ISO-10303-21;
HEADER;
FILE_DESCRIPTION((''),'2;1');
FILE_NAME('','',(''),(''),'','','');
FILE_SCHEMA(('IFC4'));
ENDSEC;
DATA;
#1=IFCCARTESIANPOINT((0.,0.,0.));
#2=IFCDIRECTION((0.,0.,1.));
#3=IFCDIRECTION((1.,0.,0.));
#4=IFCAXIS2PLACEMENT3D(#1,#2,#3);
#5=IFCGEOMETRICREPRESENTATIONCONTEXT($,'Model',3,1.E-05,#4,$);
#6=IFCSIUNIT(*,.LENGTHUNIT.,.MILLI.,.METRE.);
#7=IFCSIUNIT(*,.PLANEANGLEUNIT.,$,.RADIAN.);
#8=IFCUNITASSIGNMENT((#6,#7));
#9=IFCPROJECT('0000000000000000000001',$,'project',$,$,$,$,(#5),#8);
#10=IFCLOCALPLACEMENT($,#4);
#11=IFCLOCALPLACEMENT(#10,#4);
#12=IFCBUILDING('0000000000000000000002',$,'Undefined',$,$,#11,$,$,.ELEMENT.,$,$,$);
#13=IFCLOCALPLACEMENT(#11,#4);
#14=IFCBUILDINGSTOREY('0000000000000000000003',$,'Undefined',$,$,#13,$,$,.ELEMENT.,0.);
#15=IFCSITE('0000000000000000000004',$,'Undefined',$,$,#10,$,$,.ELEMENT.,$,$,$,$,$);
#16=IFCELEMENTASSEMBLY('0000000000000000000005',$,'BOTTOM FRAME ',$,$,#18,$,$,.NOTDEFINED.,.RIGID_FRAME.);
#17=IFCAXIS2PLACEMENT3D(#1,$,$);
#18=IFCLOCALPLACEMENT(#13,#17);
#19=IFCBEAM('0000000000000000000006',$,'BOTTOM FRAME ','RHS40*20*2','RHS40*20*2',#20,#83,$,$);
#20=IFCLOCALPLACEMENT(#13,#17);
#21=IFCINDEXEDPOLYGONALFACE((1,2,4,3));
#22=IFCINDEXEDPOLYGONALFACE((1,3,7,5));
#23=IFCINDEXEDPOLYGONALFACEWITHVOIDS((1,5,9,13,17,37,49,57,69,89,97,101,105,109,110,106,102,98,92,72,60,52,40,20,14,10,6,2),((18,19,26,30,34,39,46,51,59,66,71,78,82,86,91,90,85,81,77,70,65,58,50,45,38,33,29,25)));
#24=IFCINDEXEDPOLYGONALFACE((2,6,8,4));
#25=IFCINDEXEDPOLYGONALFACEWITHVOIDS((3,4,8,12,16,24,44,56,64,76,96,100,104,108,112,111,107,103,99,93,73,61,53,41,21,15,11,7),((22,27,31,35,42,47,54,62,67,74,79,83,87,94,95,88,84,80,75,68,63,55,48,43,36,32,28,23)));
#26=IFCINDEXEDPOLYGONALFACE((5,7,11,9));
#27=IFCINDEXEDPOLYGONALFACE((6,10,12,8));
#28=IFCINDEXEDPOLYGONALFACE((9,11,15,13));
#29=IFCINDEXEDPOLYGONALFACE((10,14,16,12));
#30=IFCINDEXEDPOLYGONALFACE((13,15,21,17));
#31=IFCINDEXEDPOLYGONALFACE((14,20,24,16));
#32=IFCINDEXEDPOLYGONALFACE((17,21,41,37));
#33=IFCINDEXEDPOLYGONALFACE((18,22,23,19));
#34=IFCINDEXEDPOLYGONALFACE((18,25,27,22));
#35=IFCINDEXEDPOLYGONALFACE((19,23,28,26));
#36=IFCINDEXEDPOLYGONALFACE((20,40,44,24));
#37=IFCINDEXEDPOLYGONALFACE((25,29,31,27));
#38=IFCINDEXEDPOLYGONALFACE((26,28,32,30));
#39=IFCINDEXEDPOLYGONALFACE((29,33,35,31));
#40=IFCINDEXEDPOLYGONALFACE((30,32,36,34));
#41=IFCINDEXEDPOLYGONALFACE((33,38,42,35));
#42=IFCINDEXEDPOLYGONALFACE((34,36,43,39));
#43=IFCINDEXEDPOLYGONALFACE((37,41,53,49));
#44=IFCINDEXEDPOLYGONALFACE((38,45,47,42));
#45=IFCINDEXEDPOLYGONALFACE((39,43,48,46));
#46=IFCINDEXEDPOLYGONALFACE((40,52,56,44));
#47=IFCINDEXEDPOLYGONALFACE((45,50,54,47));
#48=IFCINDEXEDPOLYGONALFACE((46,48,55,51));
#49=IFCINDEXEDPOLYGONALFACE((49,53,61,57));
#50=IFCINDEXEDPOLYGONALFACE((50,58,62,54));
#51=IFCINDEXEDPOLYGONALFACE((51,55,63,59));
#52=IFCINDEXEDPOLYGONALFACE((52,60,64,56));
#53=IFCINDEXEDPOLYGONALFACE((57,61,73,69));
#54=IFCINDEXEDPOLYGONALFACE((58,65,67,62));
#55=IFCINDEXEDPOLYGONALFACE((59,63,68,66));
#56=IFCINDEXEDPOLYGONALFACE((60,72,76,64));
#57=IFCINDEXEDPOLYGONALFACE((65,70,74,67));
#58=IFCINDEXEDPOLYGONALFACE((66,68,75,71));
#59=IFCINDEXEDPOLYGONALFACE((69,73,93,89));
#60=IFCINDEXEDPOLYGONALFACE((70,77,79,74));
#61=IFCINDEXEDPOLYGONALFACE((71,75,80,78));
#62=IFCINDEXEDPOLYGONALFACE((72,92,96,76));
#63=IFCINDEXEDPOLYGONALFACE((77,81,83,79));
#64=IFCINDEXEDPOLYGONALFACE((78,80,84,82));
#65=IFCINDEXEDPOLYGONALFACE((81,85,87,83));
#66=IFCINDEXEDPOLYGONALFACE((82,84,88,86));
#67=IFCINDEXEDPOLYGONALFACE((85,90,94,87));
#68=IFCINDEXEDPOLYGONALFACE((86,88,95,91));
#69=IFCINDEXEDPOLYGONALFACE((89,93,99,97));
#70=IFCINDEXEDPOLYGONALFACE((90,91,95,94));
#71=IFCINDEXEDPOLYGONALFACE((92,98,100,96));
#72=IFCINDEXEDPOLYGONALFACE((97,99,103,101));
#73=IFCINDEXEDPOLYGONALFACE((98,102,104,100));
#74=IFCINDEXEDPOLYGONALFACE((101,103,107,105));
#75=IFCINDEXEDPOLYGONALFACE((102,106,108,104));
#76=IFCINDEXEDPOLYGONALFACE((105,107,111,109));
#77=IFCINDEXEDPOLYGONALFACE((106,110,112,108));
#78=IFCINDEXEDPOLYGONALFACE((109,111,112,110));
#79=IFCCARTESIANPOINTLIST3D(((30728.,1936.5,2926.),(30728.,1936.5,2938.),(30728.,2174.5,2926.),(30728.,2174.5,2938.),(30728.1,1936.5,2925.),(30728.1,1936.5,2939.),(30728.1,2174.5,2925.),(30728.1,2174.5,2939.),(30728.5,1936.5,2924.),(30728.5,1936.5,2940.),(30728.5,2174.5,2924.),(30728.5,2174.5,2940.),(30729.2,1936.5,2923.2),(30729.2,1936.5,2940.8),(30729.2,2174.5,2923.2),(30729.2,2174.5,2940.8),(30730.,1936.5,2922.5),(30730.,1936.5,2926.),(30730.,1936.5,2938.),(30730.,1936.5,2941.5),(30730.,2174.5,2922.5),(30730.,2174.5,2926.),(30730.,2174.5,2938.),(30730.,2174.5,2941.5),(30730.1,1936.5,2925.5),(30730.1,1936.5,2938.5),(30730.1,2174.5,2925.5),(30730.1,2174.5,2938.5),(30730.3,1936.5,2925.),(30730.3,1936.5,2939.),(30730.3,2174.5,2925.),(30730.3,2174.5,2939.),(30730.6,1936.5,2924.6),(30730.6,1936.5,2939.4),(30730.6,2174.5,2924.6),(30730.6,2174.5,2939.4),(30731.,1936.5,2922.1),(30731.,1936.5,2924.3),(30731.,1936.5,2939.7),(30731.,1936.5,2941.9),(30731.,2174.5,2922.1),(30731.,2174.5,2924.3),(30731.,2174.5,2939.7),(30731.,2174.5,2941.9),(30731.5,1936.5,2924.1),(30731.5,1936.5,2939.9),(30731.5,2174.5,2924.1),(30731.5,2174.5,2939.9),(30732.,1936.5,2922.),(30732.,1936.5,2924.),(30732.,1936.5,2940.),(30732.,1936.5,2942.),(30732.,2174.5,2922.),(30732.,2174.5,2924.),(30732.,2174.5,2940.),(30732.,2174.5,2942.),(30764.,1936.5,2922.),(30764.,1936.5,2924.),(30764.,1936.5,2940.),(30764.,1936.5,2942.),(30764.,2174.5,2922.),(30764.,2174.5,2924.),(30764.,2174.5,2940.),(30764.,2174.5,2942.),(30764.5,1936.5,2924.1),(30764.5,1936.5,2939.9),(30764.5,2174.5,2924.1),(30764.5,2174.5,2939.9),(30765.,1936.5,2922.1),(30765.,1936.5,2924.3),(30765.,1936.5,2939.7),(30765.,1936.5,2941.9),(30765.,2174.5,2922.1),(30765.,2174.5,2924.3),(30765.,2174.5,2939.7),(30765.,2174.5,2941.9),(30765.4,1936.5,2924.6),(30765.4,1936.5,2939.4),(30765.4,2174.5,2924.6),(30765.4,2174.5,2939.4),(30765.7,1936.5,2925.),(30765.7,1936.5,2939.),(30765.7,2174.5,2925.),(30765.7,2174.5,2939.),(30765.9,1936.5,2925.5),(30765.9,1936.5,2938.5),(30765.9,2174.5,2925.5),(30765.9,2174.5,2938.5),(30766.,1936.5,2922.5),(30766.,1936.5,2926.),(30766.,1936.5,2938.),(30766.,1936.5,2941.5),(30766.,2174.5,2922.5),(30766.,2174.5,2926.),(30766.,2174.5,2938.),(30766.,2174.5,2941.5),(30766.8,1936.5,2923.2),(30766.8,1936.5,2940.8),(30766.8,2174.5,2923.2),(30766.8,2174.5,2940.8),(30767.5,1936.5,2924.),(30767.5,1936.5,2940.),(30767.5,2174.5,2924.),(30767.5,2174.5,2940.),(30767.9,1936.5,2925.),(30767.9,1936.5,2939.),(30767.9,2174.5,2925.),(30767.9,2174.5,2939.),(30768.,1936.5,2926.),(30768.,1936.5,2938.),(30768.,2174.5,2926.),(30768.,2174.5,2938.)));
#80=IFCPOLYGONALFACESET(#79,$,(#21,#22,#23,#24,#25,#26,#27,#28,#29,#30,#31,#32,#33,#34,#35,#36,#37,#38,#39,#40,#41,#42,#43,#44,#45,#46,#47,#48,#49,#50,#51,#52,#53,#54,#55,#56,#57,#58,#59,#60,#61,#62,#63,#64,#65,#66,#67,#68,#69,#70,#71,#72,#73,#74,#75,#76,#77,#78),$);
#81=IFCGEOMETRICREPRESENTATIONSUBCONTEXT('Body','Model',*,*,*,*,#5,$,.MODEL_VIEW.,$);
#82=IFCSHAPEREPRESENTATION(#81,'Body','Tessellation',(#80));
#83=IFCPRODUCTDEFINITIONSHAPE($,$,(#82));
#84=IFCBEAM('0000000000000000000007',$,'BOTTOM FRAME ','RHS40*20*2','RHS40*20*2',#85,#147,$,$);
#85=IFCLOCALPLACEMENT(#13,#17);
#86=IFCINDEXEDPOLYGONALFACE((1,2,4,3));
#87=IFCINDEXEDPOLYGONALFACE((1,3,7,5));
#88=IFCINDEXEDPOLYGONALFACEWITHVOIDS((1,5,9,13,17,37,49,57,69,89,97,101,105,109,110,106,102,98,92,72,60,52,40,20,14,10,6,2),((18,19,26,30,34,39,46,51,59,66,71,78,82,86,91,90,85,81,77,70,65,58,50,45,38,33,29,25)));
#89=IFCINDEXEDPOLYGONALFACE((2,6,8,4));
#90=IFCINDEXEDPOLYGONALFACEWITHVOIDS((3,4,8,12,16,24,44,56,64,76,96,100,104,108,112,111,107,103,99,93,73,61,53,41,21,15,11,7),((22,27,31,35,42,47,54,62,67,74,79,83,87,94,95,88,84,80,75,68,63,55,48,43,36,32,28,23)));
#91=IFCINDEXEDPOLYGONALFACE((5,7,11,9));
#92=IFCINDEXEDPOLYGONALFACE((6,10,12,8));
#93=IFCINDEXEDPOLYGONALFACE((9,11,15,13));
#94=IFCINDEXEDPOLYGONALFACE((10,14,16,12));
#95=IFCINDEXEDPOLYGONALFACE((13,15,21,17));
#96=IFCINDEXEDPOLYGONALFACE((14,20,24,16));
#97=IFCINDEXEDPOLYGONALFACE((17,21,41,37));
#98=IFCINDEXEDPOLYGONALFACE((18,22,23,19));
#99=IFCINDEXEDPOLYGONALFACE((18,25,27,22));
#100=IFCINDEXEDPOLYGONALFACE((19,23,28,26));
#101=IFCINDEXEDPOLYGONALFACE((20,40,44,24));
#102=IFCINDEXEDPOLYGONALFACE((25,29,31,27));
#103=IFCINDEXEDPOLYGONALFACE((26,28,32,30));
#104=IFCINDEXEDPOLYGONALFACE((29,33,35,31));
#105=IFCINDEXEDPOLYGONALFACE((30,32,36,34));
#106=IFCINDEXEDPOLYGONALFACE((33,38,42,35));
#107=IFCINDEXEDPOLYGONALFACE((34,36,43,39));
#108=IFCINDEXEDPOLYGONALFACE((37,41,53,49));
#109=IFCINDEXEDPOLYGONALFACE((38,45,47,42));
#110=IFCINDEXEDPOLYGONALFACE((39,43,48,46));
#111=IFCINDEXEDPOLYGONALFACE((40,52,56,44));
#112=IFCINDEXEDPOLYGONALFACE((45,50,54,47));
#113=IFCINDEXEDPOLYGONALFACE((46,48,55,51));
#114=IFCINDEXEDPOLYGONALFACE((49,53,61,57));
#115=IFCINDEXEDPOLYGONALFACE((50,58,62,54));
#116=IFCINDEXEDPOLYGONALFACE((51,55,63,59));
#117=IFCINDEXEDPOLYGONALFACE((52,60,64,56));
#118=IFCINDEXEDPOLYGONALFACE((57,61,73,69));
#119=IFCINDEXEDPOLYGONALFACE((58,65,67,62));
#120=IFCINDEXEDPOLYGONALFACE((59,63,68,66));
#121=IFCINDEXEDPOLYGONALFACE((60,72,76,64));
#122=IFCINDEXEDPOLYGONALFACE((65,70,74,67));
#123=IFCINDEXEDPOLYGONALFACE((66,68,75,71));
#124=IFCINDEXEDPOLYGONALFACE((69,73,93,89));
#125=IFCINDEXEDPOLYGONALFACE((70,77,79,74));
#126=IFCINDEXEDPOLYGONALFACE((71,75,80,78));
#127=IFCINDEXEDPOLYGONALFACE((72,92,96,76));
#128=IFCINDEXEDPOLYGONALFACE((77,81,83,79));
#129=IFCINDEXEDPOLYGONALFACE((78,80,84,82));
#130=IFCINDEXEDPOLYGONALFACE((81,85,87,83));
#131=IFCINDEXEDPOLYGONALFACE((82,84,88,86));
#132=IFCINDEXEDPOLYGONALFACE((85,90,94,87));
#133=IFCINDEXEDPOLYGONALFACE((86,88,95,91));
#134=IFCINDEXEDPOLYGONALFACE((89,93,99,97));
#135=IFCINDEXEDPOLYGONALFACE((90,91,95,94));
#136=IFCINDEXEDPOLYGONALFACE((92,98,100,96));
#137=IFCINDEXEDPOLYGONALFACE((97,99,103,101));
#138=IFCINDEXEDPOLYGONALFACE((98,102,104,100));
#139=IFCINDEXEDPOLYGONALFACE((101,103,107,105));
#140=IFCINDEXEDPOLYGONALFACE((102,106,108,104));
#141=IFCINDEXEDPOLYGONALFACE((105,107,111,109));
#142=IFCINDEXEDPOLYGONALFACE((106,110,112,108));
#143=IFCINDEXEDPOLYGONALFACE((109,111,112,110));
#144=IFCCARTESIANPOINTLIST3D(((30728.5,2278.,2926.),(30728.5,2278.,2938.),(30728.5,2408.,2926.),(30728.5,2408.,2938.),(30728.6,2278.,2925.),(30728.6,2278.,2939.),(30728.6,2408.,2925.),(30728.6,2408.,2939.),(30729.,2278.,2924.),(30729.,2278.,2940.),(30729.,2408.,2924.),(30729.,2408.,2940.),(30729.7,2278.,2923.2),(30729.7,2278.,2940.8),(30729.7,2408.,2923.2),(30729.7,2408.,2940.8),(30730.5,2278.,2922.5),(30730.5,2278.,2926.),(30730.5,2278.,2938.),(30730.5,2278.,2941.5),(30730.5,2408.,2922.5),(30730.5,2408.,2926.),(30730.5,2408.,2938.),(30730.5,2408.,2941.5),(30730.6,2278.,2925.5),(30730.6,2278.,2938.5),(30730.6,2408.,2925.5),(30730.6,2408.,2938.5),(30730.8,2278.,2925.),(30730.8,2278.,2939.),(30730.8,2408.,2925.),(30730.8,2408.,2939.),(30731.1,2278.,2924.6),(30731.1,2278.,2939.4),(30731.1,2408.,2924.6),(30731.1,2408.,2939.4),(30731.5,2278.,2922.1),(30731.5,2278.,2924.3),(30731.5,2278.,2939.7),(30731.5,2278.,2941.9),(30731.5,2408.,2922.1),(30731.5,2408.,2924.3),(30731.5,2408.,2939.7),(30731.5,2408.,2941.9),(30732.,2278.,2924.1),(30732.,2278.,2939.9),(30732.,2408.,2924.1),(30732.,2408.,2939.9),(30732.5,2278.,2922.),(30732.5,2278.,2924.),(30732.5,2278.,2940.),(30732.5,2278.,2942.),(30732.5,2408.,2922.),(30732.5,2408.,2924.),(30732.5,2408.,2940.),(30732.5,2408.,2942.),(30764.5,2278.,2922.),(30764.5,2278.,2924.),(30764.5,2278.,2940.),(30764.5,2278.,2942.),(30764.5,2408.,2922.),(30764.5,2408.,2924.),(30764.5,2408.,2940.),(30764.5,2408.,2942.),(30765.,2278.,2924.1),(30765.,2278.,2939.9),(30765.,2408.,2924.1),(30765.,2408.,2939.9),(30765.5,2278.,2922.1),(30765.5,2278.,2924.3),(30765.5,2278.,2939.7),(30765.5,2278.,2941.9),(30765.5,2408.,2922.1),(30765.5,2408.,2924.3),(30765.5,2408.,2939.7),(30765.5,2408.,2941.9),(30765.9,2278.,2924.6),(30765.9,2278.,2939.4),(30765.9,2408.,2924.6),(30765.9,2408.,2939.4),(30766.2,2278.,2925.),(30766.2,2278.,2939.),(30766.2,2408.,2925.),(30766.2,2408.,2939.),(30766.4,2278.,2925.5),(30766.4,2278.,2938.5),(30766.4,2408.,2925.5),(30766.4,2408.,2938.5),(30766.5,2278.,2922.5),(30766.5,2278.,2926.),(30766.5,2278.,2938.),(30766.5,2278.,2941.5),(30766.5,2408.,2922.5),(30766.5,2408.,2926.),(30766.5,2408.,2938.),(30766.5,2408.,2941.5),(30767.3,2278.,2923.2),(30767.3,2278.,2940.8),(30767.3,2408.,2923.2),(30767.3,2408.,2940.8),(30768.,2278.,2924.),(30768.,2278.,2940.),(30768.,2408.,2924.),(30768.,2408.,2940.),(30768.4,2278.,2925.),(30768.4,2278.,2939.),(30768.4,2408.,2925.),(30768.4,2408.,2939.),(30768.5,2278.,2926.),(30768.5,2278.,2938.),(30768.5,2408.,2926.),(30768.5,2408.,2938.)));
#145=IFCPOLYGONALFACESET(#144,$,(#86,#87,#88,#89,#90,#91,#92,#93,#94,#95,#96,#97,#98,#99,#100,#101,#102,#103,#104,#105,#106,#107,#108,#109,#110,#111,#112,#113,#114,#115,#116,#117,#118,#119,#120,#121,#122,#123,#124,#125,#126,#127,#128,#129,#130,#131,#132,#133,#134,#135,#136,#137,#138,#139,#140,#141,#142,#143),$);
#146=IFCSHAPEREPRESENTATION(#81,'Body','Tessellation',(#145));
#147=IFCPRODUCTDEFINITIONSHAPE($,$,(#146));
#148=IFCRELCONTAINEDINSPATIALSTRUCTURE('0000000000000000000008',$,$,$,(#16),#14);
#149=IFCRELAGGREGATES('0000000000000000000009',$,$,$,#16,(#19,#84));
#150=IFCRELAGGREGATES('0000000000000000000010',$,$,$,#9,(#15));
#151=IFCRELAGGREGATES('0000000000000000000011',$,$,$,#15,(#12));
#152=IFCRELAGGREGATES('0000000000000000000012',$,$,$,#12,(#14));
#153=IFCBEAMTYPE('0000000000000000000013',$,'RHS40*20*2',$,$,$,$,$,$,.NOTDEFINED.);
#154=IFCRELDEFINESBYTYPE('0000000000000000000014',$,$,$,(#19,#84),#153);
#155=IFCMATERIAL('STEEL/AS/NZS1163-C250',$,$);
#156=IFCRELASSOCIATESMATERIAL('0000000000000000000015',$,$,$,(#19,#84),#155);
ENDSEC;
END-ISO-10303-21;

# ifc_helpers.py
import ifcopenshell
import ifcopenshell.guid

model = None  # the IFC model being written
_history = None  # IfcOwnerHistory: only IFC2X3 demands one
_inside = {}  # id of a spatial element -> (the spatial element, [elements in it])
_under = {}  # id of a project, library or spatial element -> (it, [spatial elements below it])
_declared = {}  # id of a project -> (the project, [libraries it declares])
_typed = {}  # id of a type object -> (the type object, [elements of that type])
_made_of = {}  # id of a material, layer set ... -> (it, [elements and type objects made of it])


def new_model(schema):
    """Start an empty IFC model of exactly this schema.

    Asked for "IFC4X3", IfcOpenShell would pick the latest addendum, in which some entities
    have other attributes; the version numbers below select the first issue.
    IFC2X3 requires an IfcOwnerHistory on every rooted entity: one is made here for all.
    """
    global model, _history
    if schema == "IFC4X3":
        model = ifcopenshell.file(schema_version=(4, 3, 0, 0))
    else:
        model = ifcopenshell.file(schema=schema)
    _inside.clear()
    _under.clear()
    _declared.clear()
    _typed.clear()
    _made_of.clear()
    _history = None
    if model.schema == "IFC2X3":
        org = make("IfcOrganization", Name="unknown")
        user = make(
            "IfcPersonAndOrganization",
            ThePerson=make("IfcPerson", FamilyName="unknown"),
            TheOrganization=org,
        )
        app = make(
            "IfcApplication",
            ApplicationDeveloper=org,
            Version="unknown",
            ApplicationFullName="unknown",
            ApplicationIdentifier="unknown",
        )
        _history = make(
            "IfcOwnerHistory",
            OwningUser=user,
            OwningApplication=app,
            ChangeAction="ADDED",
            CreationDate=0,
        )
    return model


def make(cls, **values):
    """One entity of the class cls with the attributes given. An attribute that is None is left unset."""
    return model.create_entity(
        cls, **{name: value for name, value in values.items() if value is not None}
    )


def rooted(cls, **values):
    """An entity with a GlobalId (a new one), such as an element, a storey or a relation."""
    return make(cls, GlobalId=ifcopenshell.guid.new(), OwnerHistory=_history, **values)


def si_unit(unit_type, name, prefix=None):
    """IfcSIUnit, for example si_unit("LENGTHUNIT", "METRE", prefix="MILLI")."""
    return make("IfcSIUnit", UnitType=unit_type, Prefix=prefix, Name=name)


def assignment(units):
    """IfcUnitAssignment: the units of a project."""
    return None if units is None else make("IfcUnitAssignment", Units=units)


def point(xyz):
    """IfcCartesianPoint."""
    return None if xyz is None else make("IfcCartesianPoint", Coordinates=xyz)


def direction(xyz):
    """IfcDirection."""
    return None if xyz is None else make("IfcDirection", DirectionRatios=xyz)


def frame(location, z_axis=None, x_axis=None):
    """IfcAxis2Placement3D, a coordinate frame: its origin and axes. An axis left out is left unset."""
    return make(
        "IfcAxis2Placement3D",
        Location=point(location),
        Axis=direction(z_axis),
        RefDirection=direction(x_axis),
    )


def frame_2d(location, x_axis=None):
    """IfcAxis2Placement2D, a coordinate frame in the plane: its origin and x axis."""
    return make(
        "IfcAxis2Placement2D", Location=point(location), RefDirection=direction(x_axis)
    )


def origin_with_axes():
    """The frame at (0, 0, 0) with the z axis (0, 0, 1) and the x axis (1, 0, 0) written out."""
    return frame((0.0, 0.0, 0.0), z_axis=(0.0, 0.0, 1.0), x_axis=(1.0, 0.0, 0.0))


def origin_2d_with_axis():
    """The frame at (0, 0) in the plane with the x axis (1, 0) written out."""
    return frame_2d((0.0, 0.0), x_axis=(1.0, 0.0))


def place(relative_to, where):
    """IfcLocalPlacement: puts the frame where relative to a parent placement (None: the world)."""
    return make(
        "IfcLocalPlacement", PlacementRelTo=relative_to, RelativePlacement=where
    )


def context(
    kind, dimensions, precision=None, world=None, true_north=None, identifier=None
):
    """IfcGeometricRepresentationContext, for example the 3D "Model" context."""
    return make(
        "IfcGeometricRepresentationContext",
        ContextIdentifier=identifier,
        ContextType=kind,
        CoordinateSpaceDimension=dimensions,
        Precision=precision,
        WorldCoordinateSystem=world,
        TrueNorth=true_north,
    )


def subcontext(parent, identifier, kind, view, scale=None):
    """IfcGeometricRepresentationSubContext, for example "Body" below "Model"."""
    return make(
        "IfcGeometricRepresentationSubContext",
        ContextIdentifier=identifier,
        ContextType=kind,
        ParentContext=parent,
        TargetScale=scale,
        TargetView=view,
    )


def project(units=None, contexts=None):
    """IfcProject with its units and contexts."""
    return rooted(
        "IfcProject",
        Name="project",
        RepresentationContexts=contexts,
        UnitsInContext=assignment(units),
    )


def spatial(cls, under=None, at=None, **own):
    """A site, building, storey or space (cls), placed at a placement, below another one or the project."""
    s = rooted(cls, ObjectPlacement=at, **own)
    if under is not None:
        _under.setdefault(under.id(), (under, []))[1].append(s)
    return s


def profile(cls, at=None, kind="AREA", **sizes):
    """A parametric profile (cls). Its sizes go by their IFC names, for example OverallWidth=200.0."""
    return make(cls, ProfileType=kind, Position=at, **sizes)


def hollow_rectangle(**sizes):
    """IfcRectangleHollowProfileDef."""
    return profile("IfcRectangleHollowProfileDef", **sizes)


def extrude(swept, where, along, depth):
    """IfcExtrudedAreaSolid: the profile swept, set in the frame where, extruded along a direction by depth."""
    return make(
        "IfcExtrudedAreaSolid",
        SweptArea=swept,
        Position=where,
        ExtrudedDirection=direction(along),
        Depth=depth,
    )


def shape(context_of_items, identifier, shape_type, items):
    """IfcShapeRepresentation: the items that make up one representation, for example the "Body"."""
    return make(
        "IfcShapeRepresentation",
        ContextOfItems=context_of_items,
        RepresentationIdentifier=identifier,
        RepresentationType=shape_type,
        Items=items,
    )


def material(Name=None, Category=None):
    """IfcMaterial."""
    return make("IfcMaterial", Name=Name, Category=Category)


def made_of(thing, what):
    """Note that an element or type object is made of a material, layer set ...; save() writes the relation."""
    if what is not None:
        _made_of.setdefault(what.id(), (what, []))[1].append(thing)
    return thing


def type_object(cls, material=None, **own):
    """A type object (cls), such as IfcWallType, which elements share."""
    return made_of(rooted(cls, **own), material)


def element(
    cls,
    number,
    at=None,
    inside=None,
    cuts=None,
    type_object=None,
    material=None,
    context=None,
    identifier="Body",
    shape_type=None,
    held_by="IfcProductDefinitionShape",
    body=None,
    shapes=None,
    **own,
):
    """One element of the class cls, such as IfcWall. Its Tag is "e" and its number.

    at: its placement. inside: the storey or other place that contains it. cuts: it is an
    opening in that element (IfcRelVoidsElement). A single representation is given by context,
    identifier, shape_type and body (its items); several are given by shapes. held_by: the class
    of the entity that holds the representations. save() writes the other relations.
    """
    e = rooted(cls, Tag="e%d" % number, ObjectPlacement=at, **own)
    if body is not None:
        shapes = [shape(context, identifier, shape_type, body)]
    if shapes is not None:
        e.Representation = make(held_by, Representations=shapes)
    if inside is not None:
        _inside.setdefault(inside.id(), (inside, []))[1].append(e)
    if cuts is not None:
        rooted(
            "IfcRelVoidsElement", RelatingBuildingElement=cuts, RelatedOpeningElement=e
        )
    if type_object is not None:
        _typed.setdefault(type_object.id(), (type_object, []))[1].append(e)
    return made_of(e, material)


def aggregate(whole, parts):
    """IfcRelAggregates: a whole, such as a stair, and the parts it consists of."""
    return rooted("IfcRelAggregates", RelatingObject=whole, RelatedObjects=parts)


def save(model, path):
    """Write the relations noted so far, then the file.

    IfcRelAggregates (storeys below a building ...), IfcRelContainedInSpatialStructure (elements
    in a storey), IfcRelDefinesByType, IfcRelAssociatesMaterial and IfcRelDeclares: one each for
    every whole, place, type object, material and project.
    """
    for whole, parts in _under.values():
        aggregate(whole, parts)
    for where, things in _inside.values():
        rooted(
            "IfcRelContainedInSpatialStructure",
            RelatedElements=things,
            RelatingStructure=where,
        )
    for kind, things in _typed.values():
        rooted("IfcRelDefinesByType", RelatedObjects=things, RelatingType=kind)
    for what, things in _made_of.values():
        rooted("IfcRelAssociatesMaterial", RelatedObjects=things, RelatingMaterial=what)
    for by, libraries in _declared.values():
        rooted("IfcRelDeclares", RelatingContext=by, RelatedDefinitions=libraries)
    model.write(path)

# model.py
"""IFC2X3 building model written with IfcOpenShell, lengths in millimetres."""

from ifc_helpers import new_model, si_unit, frame, origin_with_axes, origin_2d_with_axis, place, context, subcontext, project, spatial, hollow_rectangle, extrude, material, type_object, element, aggregate, save


model = new_model("IFC2X3")

# Units and contexts
model_context = context("Model", 3, precision=1e-05, world=origin_with_axes())
body_context = subcontext(model_context, "Body", "Model", "MODEL_VIEW")
ifc_project = project(units=[si_unit("LENGTHUNIT", "METRE", prefix="MILLI"), si_unit("PLANEANGLEUNIT", "RADIAN")], contexts=[model_context])

# Site, building, storey
site_placement = place(None, origin_with_axes())
site = spatial("IfcSite", under=ifc_project, at=site_placement, Name="Undefined", CompositionType="ELEMENT")
building_placement = place(site_placement, origin_with_axes())
building = spatial("IfcBuilding", under=site, at=building_placement, Name="Undefined", CompositionType="ELEMENT")
storey_placement = place(building_placement, origin_with_axes())
storey = spatial("IfcBuildingStorey", under=building, at=storey_placement, Name="Undefined", CompositionType="ELEMENT", Elevation=0.0)

# Element assembly, beams
assembly_1_placement = place(storey_placement, origin_with_axes())
assembly_1 = element("IfcElementAssembly", 1, at=assembly_1_placement, inside=storey, Name="BOTTOM FRAME ", AssemblyPlace="NOTDEFINED", PredefinedType="RIGID_FRAME")
ifc_material_1 = material(Name="STEEL/AS/NZS1163-C250")
beam_type_1 = type_object("IfcBeamType", Name="RHS40*20*2", PredefinedType="NOTDEFINED")
beam_1_placement = place(assembly_1_placement, frame((30748.0, 2174.5, 2932.0), z_axis=(1.0, 0.0, 0.0), x_axis=(0.0, -1.0, 0.0)))
beam_1 = element("IfcBeam", 2, at=beam_1_placement, type_object=beam_type_1, material=ifc_material_1, Name="BOTTOM FRAME ", Description="RHS40*20*2", ObjectType="RHS40*20*2", context=body_context, shape_type="SweptSolid", body=[
    extrude(hollow_rectangle(XDim=20.0, YDim=40.0, WallThickness=2.0, InnerFilletRadius=2.0, OuterFilletRadius=4.0, at=origin_2d_with_axis()), frame((238.0, 0.0, 0.0), z_axis=(-1.0, 0.0, 0.0), x_axis=(0.0, -1.0, 0.0)), (0.0, 0.0, 1.0), 238.0),
])
beam_2_placement = place(assembly_1_placement, frame((30748.5, 2408.0, 2932.0), z_axis=(1.0, 0.0, 0.0), x_axis=(0.0, -1.0, 0.0)))
beam_2 = element("IfcBeam", 3, at=beam_2_placement, type_object=beam_type_1, material=ifc_material_1, Name="BOTTOM FRAME ", Description="RHS40*20*2", ObjectType="RHS40*20*2", context=body_context, shape_type="SweptSolid", body=[
    extrude(hollow_rectangle(XDim=20.0, YDim=40.0, WallThickness=2.0, InnerFilletRadius=2.0, OuterFilletRadius=4.0, at=origin_2d_with_axis()), frame((130.0, 0.0, 0.0), z_axis=(-1.0, 0.0, 0.0), x_axis=(0.0, -1.0, 0.0)), (0.0, 0.0, 1.0), 130.0),
])
aggregate(assembly_1, [beam_1, beam_2])

save(model, "model.ifc")
